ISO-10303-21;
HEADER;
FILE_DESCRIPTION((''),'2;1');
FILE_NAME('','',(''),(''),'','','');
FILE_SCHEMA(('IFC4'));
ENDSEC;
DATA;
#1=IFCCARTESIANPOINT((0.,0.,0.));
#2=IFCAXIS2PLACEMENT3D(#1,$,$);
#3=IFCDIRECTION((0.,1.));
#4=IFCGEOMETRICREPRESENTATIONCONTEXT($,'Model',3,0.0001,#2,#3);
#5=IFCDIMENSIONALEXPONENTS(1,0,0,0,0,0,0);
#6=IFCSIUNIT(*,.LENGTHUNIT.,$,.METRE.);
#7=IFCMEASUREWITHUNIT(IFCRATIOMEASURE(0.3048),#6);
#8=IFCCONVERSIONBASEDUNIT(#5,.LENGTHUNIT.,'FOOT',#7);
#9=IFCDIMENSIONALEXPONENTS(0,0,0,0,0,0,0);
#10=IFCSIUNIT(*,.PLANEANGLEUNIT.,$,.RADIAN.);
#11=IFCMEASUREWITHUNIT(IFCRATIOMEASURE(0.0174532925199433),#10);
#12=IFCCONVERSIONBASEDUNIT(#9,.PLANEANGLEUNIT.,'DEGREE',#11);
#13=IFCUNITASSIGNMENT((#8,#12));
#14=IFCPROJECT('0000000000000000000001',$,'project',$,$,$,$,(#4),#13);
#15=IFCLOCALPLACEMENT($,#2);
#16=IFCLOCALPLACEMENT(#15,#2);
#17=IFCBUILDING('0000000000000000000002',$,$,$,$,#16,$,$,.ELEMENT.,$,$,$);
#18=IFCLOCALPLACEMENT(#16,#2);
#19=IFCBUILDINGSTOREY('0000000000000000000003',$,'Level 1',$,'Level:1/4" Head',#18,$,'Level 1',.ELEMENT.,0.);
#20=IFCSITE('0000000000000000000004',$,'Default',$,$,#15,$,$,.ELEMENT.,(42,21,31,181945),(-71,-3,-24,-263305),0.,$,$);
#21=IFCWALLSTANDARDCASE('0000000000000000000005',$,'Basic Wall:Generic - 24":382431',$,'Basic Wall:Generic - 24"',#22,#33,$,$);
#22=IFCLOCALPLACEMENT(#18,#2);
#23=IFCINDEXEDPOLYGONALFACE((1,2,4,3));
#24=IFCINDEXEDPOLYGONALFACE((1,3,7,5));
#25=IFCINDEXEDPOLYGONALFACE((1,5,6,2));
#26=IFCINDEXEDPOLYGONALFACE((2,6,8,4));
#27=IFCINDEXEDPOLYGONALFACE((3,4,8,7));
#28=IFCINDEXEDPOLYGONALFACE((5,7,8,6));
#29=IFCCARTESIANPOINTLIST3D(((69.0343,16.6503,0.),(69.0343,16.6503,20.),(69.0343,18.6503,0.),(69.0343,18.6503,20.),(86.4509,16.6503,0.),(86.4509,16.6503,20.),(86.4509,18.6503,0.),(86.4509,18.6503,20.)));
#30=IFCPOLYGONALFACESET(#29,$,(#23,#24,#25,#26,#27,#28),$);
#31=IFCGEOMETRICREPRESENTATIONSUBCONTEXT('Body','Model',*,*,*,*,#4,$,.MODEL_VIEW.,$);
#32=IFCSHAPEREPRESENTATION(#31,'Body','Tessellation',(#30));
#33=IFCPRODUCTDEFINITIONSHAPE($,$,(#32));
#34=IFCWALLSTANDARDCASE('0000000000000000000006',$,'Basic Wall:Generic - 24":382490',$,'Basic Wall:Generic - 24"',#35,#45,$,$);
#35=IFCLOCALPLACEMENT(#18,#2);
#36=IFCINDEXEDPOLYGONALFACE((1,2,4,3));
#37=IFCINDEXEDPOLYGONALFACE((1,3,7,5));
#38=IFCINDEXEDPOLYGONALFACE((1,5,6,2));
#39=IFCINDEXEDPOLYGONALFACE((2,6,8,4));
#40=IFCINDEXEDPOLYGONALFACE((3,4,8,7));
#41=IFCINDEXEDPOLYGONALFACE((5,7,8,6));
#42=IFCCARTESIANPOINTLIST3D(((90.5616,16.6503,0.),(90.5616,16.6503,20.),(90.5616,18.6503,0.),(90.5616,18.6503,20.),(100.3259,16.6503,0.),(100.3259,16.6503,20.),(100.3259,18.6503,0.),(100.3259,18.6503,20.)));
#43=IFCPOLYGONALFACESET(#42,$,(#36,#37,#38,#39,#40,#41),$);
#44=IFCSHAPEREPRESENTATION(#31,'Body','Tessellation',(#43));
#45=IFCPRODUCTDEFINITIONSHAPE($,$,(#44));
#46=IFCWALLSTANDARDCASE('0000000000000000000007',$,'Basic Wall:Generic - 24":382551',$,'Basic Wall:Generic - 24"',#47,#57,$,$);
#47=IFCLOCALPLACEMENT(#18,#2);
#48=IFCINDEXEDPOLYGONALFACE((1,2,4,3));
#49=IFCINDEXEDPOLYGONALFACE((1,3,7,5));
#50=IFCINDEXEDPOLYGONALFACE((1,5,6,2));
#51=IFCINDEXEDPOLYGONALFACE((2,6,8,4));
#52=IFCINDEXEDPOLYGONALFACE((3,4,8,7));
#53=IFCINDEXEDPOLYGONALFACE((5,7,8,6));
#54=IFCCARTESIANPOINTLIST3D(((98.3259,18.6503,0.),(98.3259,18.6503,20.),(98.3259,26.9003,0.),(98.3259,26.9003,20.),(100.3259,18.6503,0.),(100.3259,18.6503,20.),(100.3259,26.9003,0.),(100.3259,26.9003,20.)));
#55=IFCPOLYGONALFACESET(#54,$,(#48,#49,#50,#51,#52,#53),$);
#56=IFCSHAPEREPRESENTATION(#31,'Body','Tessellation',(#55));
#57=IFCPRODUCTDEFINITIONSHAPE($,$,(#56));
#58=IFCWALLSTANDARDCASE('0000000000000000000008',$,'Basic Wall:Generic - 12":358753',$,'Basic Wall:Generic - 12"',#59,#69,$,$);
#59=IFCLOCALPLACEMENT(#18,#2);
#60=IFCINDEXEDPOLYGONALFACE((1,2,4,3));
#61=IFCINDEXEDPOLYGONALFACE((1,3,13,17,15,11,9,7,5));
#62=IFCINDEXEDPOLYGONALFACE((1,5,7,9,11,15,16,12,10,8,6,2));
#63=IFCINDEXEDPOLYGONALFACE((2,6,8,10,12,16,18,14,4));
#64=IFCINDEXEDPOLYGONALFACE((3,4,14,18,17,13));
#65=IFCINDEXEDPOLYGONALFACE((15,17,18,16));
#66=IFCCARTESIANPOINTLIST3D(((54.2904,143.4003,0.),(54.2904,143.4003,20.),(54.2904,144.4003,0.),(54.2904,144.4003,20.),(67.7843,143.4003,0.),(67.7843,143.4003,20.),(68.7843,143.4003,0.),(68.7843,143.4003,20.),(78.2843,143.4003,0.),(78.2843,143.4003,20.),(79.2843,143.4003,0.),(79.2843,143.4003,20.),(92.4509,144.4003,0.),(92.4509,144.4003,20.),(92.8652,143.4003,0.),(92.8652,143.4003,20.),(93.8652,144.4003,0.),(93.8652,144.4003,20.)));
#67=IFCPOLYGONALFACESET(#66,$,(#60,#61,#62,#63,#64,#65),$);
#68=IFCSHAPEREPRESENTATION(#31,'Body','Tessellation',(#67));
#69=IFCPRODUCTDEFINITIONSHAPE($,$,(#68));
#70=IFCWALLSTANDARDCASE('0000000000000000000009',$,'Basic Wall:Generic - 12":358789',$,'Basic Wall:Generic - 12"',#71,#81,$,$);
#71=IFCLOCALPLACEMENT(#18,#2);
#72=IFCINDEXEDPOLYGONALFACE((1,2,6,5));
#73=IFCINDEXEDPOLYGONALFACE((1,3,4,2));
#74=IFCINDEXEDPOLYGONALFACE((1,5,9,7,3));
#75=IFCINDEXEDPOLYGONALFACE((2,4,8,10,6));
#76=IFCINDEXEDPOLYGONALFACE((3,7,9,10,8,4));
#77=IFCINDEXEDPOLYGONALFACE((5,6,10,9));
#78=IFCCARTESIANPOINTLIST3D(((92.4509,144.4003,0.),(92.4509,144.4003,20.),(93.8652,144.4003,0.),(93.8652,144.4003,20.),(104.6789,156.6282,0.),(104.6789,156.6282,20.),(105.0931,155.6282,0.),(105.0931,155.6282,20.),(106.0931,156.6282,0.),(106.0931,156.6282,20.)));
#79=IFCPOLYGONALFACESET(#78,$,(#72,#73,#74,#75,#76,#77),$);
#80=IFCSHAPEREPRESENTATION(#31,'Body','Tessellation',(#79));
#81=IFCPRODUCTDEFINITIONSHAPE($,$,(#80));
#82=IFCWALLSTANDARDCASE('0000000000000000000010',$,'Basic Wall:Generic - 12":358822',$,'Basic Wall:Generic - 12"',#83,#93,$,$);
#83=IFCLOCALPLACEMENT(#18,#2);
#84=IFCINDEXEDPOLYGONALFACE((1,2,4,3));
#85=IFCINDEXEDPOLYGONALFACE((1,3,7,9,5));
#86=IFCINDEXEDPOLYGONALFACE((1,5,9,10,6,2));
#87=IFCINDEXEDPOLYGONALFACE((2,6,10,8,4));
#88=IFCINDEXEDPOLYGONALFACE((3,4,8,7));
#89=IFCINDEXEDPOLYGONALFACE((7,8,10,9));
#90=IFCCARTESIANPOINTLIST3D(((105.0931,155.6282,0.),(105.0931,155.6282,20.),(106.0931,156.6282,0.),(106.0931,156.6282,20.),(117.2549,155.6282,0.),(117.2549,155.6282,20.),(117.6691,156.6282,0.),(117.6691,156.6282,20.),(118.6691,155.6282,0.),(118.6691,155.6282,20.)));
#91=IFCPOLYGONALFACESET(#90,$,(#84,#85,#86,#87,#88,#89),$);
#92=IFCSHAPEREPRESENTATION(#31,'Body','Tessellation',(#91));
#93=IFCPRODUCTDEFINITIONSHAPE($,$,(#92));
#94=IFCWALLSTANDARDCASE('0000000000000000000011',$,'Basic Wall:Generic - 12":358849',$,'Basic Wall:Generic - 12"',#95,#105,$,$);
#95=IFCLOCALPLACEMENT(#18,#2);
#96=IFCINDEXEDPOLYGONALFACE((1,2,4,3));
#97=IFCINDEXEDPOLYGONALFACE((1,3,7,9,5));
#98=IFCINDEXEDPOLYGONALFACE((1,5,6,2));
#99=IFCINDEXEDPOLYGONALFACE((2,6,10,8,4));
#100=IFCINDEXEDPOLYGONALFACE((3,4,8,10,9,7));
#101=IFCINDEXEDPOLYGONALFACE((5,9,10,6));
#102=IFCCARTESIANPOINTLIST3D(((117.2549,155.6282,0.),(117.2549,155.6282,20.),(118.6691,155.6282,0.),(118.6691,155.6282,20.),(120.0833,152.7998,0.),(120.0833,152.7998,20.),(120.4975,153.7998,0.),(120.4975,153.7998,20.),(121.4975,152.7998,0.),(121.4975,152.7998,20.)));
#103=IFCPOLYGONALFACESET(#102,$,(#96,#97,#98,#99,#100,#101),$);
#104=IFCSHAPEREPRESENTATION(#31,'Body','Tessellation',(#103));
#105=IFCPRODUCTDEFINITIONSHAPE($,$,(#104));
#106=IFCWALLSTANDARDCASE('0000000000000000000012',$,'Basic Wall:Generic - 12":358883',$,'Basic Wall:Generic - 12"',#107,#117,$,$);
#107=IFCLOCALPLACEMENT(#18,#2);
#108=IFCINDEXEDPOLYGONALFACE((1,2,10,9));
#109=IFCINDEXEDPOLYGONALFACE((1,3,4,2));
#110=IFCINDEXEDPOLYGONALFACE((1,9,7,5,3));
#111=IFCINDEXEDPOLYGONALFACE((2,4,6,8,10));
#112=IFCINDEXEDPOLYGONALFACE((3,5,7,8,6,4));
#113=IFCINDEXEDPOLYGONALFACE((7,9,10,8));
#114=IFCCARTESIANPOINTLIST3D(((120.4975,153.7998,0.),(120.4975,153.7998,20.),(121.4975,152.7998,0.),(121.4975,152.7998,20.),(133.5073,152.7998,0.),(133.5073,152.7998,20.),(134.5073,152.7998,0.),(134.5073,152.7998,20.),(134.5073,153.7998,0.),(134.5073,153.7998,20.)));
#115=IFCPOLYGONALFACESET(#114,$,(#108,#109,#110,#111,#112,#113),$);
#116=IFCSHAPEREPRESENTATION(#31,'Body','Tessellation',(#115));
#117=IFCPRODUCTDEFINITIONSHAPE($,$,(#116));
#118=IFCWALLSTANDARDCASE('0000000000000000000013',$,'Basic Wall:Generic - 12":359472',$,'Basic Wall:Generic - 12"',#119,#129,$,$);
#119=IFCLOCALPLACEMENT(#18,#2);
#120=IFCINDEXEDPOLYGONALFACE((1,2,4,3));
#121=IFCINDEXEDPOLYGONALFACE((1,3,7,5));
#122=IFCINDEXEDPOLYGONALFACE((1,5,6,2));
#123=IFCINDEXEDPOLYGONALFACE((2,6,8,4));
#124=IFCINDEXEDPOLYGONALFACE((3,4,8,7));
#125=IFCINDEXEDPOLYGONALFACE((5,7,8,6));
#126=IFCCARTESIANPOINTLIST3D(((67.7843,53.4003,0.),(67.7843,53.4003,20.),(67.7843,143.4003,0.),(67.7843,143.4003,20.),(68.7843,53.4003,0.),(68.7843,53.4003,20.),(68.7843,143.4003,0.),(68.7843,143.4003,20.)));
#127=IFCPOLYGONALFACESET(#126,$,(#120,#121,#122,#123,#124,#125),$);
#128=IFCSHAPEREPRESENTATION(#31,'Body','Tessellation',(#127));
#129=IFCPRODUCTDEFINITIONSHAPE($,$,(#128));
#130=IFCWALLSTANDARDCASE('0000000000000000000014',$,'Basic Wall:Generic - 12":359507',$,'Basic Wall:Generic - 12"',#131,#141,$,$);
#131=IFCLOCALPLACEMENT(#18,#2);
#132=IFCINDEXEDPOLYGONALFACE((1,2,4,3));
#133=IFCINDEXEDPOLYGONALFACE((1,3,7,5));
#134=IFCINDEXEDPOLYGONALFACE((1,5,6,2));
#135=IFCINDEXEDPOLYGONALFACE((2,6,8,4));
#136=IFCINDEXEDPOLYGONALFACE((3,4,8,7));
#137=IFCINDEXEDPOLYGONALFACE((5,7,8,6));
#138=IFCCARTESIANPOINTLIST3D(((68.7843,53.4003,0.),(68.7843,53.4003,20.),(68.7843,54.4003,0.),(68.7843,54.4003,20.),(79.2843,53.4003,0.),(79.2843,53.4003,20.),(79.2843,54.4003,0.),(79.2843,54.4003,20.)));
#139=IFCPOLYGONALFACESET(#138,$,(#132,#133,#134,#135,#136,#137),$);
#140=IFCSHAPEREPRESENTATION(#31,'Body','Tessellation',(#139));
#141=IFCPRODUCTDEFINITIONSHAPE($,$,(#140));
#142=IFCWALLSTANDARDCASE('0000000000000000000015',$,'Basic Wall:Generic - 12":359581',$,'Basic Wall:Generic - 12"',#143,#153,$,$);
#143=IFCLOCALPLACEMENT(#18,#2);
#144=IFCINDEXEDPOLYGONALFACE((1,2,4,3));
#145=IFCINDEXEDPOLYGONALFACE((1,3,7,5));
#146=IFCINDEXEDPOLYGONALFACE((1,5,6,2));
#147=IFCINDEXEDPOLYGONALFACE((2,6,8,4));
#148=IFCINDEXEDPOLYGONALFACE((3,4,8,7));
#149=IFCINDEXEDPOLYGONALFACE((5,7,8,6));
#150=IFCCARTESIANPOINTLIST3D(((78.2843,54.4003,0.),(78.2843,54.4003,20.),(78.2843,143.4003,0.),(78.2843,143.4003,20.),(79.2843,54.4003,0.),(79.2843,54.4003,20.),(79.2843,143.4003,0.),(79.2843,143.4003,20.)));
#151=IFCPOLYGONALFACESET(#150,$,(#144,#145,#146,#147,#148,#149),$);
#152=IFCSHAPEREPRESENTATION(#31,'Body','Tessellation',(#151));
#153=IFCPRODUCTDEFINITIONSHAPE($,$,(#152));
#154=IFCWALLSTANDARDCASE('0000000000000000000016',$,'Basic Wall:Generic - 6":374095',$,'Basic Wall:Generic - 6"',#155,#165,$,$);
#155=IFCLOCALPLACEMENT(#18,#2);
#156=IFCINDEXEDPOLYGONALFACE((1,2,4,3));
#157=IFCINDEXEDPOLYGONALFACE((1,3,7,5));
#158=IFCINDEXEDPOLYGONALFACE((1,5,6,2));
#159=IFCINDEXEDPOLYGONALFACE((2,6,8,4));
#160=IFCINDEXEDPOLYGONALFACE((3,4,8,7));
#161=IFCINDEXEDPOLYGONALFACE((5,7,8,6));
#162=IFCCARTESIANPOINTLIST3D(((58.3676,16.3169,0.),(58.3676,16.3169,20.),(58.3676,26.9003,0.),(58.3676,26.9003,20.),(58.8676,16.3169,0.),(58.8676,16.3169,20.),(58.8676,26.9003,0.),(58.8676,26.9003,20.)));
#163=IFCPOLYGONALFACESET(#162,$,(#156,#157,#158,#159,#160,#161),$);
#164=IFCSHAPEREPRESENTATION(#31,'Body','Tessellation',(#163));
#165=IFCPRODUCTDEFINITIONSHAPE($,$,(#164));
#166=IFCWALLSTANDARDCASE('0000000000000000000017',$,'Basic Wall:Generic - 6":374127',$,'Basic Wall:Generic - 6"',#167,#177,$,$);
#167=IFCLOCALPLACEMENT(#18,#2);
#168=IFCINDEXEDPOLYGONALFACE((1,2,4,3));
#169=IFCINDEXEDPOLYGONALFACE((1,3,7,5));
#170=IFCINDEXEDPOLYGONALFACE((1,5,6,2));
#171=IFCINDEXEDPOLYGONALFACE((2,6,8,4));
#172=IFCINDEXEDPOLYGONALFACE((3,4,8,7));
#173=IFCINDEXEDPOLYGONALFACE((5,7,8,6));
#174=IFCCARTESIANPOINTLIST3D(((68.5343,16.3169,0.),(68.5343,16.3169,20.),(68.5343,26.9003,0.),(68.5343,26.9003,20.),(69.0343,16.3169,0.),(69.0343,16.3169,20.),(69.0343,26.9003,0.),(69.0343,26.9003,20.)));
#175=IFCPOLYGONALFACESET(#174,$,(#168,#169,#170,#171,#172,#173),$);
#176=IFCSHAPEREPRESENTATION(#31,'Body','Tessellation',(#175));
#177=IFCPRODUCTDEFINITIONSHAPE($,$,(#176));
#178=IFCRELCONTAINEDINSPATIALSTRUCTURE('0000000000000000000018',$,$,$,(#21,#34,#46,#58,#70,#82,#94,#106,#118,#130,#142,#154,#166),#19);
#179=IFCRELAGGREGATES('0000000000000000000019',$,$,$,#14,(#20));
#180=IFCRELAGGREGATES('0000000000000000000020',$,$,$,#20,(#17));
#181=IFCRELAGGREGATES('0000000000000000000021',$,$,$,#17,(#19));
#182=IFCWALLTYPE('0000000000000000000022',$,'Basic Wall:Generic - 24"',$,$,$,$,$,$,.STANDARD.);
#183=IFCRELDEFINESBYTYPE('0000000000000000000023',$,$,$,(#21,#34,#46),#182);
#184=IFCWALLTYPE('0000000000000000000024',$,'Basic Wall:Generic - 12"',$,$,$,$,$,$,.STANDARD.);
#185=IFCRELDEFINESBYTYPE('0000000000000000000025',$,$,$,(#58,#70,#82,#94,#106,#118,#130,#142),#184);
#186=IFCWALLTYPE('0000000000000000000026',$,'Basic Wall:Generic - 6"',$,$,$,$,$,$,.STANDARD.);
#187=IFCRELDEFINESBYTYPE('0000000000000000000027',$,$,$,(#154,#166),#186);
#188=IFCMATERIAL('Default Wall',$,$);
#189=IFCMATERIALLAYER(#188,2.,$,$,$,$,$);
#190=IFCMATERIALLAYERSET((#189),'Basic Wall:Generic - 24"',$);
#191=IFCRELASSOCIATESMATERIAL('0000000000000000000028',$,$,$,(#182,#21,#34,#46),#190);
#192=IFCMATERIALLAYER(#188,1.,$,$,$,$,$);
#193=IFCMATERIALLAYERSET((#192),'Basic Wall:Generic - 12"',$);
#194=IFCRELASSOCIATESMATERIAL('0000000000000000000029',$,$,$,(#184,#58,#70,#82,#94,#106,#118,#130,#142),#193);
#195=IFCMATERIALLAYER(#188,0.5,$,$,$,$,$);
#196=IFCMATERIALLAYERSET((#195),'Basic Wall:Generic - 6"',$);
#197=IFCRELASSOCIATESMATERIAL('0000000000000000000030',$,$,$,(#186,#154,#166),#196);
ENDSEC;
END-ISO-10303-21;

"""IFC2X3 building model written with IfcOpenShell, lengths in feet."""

from ifc_helpers import new_model, entity, si_unit, converted_unit, direction, frame, frame_2d, origin, place, context, subcontext, project, spatial, polyline, rectangle, outline, extrude, material, layer, layer_set, layer_usage, type_object, element, save


model = new_model("IFC2X3")

# Units and contexts
model_context = context("Model", 3, precision=0.0001, world=origin(), true_north=direction((0.0, 1.0)))
body_context = subcontext(model_context, "Body", "Model", "MODEL_VIEW")
ifc_project = project(units=[converted_unit("LENGTHUNIT", "FOOT", entity("IfcRatioMeasure", 0.3048), si_unit("LENGTHUNIT", "METRE"), dimensions=[1, 0, 0, 0, 0, 0, 0]), converted_unit("PLANEANGLEUNIT", "DEGREE", entity("IfcRatioMeasure", 0.0174532925199433), si_unit("PLANEANGLEUNIT", "RADIAN"), dimensions=[0, 0, 0, 0, 0, 0, 0])], contexts=[model_context])

# Site, building, storey
site_placement = place(None, origin())
site = spatial("IfcSite", under=ifc_project, at=site_placement, Name="Default", CompositionType="ELEMENT", RefLatitude=(42, 21, 31, 181945), RefLongitude=(-71, -3, -24, -263305), RefElevation=0.0)
building_placement = place(site_placement, origin())
building = spatial("IfcBuilding", under=site, at=building_placement, CompositionType="ELEMENT")
storey_placement = place(building_placement, origin())
storey = spatial("IfcBuildingStorey", under=building, at=storey_placement, Name="Level 1", ObjectType="Level:1/4\" Head", LongName="Level 1", CompositionType="ELEMENT", Elevation=0.0)

# Walls
ifc_material = material(Name="Default Wall")
ifc_layer_1 = layer(ifc_material, 2.0)
ifc_layer_set_1 = layer_set([ifc_layer_1], Name="Basic Wall:Generic - 24\"")
ifc_layer_usage_1 = layer_usage(ifc_layer_set_1, "AXIS2", "NEGATIVE", 1.0)
wall_type_1 = type_object("IfcWallType", Name="Basic Wall:Generic - 24\"", PredefinedType="STANDARD", material=ifc_layer_set_1)
wall_1_placement = place(storey_placement, frame((69.0343, 17.6503, 0.0)))
element("IfcWallStandardCase", 1, at=wall_1_placement, inside=storey, type_object=wall_type_1, material=ifc_layer_usage_1, Name="Basic Wall:Generic - 24\":382431", ObjectType="Basic Wall:Generic - 24\"", context=body_context, shape_type="SweptSolid", body=[
    extrude(rectangle(XDim=17.4167, YDim=2.0, at=frame_2d((8.7083, 0.0), x_axis=(-1.0, 0.0))), origin(), (0.0, 0.0, 1.0), 20.0),
])
ifc_layer_usage_2 = layer_usage(ifc_layer_set_1, "AXIS2", "NEGATIVE", 1.0)
wall_2_placement = place(storey_placement, frame((90.5616, 17.6503, 0.0)))
element("IfcWallStandardCase", 2, at=wall_2_placement, inside=storey, type_object=wall_type_1, material=ifc_layer_usage_2, Name="Basic Wall:Generic - 24\":382490", ObjectType="Basic Wall:Generic - 24\"", context=body_context, shape_type="SweptSolid", body=[
    extrude(rectangle(XDim=9.7643, YDim=2.0, at=frame_2d((4.8822, 0.0), x_axis=(-1.0, 0.0))), origin(), (0.0, 0.0, 1.0), 20.0),
])
ifc_layer_usage_3 = layer_usage(ifc_layer_set_1, "AXIS2", "NEGATIVE", 1.0)
wall_3_placement = place(storey_placement, frame((99.3259, 18.6503, 0.0), z_axis=(0.0, 0.0, 1.0), x_axis=(0.0, 1.0, 0.0)))
element("IfcWallStandardCase", 3, at=wall_3_placement, inside=storey, type_object=wall_type_1, material=ifc_layer_usage_3, Name="Basic Wall:Generic - 24\":382551", ObjectType="Basic Wall:Generic - 24\"", context=body_context, shape_type="SweptSolid", body=[
    extrude(rectangle(XDim=8.25, YDim=2.0, at=frame_2d((4.125, 0.0), x_axis=(-1.0, 0.0))), origin(), (0.0, 0.0, 1.0), 20.0),
])
ifc_layer_2 = layer(ifc_material, 1.0)
ifc_layer_set_2 = layer_set([ifc_layer_2], Name="Basic Wall:Generic - 12\"")
ifc_layer_usage_4 = layer_usage(ifc_layer_set_2, "AXIS2", "NEGATIVE", 0.5)
wall_type_2 = type_object("IfcWallType", Name="Basic Wall:Generic - 12\"", PredefinedType="STANDARD", material=ifc_layer_set_2)
wall_4_placement = place(storey_placement, frame((54.2904, 143.9003, 0.0)))
element("IfcWallStandardCase", 4, at=wall_4_placement, inside=storey, type_object=wall_type_2, material=ifc_layer_usage_4, Name="Basic Wall:Generic - 12\":358753", ObjectType="Basic Wall:Generic - 12\"", context=body_context, shape_type="SweptSolid", body=[
    extrude(outline(polyline([(38.5747, -0.5), (39.5747, 0.5), (38.1605, 0.5), (0.0, 0.5), (0.0, -0.5), (13.4938, -0.5), (14.4938, -0.5), (23.9938, -0.5), (24.9938, -0.5), (38.5747, -0.5)])), origin(), (0.0, 0.0, 1.0), 20.0),
])
ifc_layer_usage_5 = layer_usage(ifc_layer_set_2, "AXIS2", "NEGATIVE", 0.5)
wall_5_placement = place(storey_placement, frame((92.8045, 144.0467, 0.0), z_axis=(0.0, 0.0, 1.0), x_axis=(0.707107, 0.707107, 0.0)))
element("IfcWallStandardCase", 5, at=wall_5_placement, inside=storey, type_object=wall_type_2, material=ifc_layer_usage_5, Name="Basic Wall:Generic - 12\":358789", ObjectType="Basic Wall:Generic - 12\"", context=body_context, shape_type="SweptSolid", body=[
    extrude(outline(polyline([(18.2929, -0.5), (17.2929, 0.5), (0.0, 0.5), (1.0, -0.5), (16.8787, -0.5), (18.2929, -0.5)])), origin(), (0.0, 0.0, 1.0), 20.0),
])
ifc_layer_usage_6 = layer_usage(ifc_layer_set_2, "AXIS2", "NEGATIVE", 0.5)
wall_6_placement = place(storey_placement, frame((105.0931, 156.1282, 0.0)))
element("IfcWallStandardCase", 6, at=wall_6_placement, inside=storey, type_object=wall_type_2, material=ifc_layer_usage_6, Name="Basic Wall:Generic - 12\":358822", ObjectType="Basic Wall:Generic - 12\"", context=body_context, shape_type="SweptSolid", body=[
    extrude(outline(polyline([(13.576, -0.5), (12.576, 0.5), (1.0, 0.5), (0.0, -0.5), (12.1618, -0.5), (13.576, -0.5)])), origin(), (0.0, 0.0, 1.0), 20.0),
])
ifc_layer_usage_7 = layer_usage(ifc_layer_set_2, "AXIS2", "NEGATIVE", 0.5)
wall_7_placement = place(storey_placement, frame((117.6085, 155.9818, 0.0), z_axis=(0.0, 0.0, 1.0), x_axis=(0.707107, -0.707107, 0.0)))
element("IfcWallStandardCase", 7, at=wall_7_placement, inside=storey, type_object=wall_type_2, material=ifc_layer_usage_7, Name="Basic Wall:Generic - 12\":358849", ObjectType="Basic Wall:Generic - 12\"", context=body_context, shape_type="SweptSolid", body=[
    extrude(outline(polyline([(4.0, -0.5), (5.0, 0.5), (3.5858, 0.5), (1.0, 0.5), (0.0, -0.5), (4.0, -0.5)])), origin(), (0.0, 0.0, 1.0), 20.0),
])
ifc_layer_usage_8 = layer_usage(ifc_layer_set_2, "AXIS2", "NEGATIVE", 0.5)
wall_8_placement = place(storey_placement, frame((120.4975, 153.2998, 0.0)))
element("IfcWallStandardCase", 8, at=wall_8_placement, inside=storey, type_object=wall_type_2, material=ifc_layer_usage_8, Name="Basic Wall:Generic - 12\":358883", ObjectType="Basic Wall:Generic - 12\"", context=body_context, shape_type="SweptSolid", body=[
    extrude(outline(polyline([(14.0098, -0.5), (14.0098, 0.5), (0.0, 0.5), (1.0, -0.5), (13.0098, -0.5), (14.0098, -0.5)])), origin(), (0.0, 0.0, 1.0), 20.0),
])
ifc_layer_usage_9 = layer_usage(ifc_layer_set_2, "AXIS2", "NEGATIVE", 0.5)
wall_9_placement = place(storey_placement, frame((68.2843, 143.4003, 0.0), z_axis=(0.0, 0.0, 1.0), x_axis=(0.0, -1.0, 0.0)))
element("IfcWallStandardCase", 9, at=wall_9_placement, inside=storey, type_object=wall_type_2, material=ifc_layer_usage_9, Name="Basic Wall:Generic - 12\":359472", ObjectType="Basic Wall:Generic - 12\"", context=body_context, shape_type="SweptSolid", body=[
    extrude(rectangle(XDim=90.0, YDim=1.0, at=frame_2d((45.0, 0.0), x_axis=(-1.0, 0.0))), origin(), (0.0, 0.0, 1.0), 20.0),
])
ifc_layer_usage_10 = layer_usage(ifc_layer_set_2, "AXIS2", "NEGATIVE", 0.5)
wall_10_placement = place(storey_placement, frame((68.7843, 53.9003, 0.0)))
element("IfcWallStandardCase", 10, at=wall_10_placement, inside=storey, type_object=wall_type_2, material=ifc_layer_usage_10, Name="Basic Wall:Generic - 12\":359507", ObjectType="Basic Wall:Generic - 12\"", context=body_context, shape_type="SweptSolid", body=[
    extrude(rectangle(XDim=10.5, YDim=1.0, at=frame_2d((5.25, 0.0), x_axis=(-1.0, 0.0))), origin(), (0.0, 0.0, 1.0), 20.0),
])
ifc_layer_usage_11 = layer_usage(ifc_layer_set_2, "AXIS2", "NEGATIVE", 0.5)
wall_11_placement = place(storey_placement, frame((78.7843, 54.4003, 0.0), z_axis=(0.0, 0.0, 1.0), x_axis=(0.0, 1.0, 0.0)))
element("IfcWallStandardCase", 11, at=wall_11_placement, inside=storey, type_object=wall_type_2, material=ifc_layer_usage_11, Name="Basic Wall:Generic - 12\":359581", ObjectType="Basic Wall:Generic - 12\"", context=body_context, shape_type="SweptSolid", body=[
    extrude(rectangle(XDim=89.0, YDim=1.0, at=frame_2d((44.5, 0.0), x_axis=(-1.0, 0.0))), origin(), (0.0, 0.0, 1.0), 20.0),
])
ifc_layer_3 = layer(ifc_material, 0.5)
ifc_layer_set_3 = layer_set([ifc_layer_3], Name="Basic Wall:Generic - 6\"")
ifc_layer_usage_12 = layer_usage(ifc_layer_set_3, "AXIS2", "NEGATIVE", 0.25)
wall_type_3 = type_object("IfcWallType", Name="Basic Wall:Generic - 6\"", PredefinedType="STANDARD", material=ifc_layer_set_3)
wall_12_placement = place(storey_placement, frame((58.6176, 26.9003, 0.0), z_axis=(0.0, 0.0, 1.0), x_axis=(0.0, -1.0, 0.0)))
element("IfcWallStandardCase", 12, at=wall_12_placement, inside=storey, type_object=wall_type_3, material=ifc_layer_usage_12, Name="Basic Wall:Generic - 6\":374095", ObjectType="Basic Wall:Generic - 6\"", context=body_context, shape_type="SweptSolid", body=[
    extrude(rectangle(XDim=10.5833, YDim=0.5, at=frame_2d((5.2917, 0.0), x_axis=(-1.0, 0.0))), origin(), (0.0, 0.0, 1.0), 20.0),
])
ifc_layer_usage_13 = layer_usage(ifc_layer_set_3, "AXIS2", "NEGATIVE", 0.25)
wall_13_placement = place(storey_placement, frame((68.7843, 26.9003, 0.0), z_axis=(0.0, 0.0, 1.0), x_axis=(0.0, -1.0, 0.0)))
element("IfcWallStandardCase", 13, at=wall_13_placement, inside=storey, type_object=wall_type_3, material=ifc_layer_usage_13, Name="Basic Wall:Generic - 6\":374127", ObjectType="Basic Wall:Generic - 6\"", context=body_context, shape_type="SweptSolid", body=[
    extrude(rectangle(XDim=10.5833, YDim=0.5, at=frame_2d((5.2917, 0.0), x_axis=(-1.0, 0.0))), origin(), (0.0, 0.0, 1.0), 20.0),
])

save(model, "model.ifc")
